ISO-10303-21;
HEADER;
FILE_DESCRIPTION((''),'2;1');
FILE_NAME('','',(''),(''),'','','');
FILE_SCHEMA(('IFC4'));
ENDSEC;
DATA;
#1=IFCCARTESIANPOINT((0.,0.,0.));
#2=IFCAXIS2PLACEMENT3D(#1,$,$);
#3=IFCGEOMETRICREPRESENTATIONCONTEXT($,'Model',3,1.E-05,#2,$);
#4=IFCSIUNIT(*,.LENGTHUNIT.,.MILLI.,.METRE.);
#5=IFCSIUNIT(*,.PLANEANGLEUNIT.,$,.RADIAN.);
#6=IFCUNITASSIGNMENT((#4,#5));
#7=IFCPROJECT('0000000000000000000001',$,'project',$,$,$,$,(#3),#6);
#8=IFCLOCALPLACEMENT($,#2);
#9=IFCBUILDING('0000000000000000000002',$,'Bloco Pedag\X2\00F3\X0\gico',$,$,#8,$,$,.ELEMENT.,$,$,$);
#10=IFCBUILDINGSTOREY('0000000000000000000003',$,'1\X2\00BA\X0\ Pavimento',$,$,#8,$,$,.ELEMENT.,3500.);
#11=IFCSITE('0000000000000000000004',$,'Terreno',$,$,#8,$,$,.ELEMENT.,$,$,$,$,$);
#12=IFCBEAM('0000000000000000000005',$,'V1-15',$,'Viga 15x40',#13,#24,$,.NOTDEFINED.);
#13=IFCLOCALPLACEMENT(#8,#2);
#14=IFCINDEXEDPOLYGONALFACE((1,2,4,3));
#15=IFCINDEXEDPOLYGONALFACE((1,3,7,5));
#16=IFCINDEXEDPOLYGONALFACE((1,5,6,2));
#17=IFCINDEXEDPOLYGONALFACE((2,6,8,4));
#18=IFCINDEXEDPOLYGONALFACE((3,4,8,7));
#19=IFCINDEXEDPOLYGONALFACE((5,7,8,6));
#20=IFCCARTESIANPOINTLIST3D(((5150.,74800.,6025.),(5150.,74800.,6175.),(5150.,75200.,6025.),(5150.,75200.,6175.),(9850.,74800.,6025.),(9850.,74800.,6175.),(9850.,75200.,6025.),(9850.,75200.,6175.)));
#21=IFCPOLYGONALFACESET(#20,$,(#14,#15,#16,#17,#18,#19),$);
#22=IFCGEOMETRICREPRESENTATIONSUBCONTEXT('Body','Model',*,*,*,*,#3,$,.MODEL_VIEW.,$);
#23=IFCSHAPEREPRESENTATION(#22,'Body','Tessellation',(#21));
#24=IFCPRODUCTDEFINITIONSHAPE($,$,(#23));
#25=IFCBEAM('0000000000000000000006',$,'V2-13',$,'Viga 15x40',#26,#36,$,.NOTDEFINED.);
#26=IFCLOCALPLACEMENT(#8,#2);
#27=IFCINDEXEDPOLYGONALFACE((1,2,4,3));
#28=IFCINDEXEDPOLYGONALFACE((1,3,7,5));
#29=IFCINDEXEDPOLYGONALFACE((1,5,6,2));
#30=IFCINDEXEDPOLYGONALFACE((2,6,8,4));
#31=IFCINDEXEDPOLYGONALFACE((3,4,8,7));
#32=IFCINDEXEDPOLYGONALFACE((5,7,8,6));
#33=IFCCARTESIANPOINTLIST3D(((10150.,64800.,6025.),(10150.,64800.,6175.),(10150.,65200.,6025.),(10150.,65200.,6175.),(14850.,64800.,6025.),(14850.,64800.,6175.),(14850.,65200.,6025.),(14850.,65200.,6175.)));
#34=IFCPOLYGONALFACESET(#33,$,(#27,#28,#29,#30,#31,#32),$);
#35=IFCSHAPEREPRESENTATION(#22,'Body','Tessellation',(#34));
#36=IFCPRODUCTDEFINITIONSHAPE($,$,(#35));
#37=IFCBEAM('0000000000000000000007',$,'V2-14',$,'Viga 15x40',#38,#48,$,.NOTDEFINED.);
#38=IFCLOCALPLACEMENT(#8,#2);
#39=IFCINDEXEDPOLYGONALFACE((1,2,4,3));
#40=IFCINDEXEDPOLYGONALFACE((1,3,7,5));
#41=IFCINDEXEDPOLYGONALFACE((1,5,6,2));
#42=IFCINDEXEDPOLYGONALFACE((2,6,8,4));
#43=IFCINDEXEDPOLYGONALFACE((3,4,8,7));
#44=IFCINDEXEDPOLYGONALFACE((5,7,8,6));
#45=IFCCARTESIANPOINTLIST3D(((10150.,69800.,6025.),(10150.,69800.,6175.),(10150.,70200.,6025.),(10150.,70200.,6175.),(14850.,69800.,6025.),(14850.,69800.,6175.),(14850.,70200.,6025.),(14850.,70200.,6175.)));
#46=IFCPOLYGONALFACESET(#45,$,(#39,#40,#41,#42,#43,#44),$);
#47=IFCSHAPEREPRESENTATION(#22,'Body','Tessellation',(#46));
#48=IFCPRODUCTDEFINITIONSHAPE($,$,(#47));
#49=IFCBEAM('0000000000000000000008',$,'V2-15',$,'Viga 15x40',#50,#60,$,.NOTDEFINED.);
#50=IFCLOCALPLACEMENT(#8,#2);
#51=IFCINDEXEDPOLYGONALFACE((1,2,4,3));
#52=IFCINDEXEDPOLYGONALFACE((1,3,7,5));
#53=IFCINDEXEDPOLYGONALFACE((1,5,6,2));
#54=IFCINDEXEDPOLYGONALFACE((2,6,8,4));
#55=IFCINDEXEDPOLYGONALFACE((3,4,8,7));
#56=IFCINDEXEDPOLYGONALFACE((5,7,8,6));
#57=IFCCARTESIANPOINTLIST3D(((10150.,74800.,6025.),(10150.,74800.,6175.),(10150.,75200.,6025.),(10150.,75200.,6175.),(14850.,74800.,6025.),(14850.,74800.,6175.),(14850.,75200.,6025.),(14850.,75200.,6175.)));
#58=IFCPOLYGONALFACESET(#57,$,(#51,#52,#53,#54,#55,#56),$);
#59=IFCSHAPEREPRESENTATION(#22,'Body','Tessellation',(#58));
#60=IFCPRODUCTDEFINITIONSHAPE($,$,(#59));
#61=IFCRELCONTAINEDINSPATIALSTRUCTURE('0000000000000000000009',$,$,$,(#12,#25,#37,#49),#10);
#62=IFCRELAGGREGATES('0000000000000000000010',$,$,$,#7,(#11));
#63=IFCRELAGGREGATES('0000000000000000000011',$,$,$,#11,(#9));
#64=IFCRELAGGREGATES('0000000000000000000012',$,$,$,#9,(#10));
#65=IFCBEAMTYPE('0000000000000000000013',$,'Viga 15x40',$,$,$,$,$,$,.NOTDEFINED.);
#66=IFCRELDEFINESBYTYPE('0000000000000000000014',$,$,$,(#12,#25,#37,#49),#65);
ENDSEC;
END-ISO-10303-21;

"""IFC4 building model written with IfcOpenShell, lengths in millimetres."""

from ifc_helpers import new_model, si_unit, frame, origin, origin_2d, place, context, subcontext, project, spatial, rectangle, extrude, type_object, element, save


model = new_model("IFC4")

# Units and contexts
model_context = context("Model", 3, precision=1e-05, world=origin())
body_context = subcontext(model_context, "Body", "Model", "MODEL_VIEW")
ifc_project = project(units=[si_unit("LENGTHUNIT", "METRE", prefix="MILLI"), si_unit("PLANEANGLEUNIT", "RADIAN")], contexts=[model_context])

# Site, building, storey
placement = place(None, origin())
site = spatial("IfcSite", under=ifc_project, at=placement, Name="Terreno", CompositionType="ELEMENT")
building = spatial("IfcBuilding", under=site, at=placement, Name="Bloco Pedagógico", CompositionType="ELEMENT")
storey = spatial("IfcBuildingStorey", under=building, at=placement, Name="1º Pavimento", CompositionType="ELEMENT", Elevation=3500.0)

# Beams
beam_type = type_object("IfcBeamType", Name="Viga 15x40", PredefinedType="NOTDEFINED")
for number, where, z_axis, x_axis, name in (
    (1, (5150.0, 75000.0, 6100.0), (1.0, 0.0, 0.0), (0.0, 1.0, 0.0), "V1-15"),
    (2, (10150.0, 65000.0, 6100.0), (1.0, 0.0, 0.0), (0.0, 1.0, 0.0), "V2-13"),
    (3, (10150.0, 70000.0, 6100.0), (1.0, 0.0, 0.0), (0.0, 1.0, 0.0), "V2-14"),
    (4, (10150.0, 75000.0, 6100.0), (1.0, 0.0, 0.0), (0.0, 1.0, 0.0), "V2-15"),
):
    element("IfcBeam", number, at=place(None, frame(where, z_axis=z_axis, x_axis=x_axis)), inside=storey, type_object=beam_type, Name=name, ObjectType="Viga 15x40", PredefinedType="NOTDEFINED", context=body_context, shape_type="SweptSolid", body=[
        extrude(rectangle(XDim=400.0, YDim=150.0, at=origin_2d()), None, (0.0, 0.0, 1.0), 4700.0),
    ])

save(model, "model.ifc")
